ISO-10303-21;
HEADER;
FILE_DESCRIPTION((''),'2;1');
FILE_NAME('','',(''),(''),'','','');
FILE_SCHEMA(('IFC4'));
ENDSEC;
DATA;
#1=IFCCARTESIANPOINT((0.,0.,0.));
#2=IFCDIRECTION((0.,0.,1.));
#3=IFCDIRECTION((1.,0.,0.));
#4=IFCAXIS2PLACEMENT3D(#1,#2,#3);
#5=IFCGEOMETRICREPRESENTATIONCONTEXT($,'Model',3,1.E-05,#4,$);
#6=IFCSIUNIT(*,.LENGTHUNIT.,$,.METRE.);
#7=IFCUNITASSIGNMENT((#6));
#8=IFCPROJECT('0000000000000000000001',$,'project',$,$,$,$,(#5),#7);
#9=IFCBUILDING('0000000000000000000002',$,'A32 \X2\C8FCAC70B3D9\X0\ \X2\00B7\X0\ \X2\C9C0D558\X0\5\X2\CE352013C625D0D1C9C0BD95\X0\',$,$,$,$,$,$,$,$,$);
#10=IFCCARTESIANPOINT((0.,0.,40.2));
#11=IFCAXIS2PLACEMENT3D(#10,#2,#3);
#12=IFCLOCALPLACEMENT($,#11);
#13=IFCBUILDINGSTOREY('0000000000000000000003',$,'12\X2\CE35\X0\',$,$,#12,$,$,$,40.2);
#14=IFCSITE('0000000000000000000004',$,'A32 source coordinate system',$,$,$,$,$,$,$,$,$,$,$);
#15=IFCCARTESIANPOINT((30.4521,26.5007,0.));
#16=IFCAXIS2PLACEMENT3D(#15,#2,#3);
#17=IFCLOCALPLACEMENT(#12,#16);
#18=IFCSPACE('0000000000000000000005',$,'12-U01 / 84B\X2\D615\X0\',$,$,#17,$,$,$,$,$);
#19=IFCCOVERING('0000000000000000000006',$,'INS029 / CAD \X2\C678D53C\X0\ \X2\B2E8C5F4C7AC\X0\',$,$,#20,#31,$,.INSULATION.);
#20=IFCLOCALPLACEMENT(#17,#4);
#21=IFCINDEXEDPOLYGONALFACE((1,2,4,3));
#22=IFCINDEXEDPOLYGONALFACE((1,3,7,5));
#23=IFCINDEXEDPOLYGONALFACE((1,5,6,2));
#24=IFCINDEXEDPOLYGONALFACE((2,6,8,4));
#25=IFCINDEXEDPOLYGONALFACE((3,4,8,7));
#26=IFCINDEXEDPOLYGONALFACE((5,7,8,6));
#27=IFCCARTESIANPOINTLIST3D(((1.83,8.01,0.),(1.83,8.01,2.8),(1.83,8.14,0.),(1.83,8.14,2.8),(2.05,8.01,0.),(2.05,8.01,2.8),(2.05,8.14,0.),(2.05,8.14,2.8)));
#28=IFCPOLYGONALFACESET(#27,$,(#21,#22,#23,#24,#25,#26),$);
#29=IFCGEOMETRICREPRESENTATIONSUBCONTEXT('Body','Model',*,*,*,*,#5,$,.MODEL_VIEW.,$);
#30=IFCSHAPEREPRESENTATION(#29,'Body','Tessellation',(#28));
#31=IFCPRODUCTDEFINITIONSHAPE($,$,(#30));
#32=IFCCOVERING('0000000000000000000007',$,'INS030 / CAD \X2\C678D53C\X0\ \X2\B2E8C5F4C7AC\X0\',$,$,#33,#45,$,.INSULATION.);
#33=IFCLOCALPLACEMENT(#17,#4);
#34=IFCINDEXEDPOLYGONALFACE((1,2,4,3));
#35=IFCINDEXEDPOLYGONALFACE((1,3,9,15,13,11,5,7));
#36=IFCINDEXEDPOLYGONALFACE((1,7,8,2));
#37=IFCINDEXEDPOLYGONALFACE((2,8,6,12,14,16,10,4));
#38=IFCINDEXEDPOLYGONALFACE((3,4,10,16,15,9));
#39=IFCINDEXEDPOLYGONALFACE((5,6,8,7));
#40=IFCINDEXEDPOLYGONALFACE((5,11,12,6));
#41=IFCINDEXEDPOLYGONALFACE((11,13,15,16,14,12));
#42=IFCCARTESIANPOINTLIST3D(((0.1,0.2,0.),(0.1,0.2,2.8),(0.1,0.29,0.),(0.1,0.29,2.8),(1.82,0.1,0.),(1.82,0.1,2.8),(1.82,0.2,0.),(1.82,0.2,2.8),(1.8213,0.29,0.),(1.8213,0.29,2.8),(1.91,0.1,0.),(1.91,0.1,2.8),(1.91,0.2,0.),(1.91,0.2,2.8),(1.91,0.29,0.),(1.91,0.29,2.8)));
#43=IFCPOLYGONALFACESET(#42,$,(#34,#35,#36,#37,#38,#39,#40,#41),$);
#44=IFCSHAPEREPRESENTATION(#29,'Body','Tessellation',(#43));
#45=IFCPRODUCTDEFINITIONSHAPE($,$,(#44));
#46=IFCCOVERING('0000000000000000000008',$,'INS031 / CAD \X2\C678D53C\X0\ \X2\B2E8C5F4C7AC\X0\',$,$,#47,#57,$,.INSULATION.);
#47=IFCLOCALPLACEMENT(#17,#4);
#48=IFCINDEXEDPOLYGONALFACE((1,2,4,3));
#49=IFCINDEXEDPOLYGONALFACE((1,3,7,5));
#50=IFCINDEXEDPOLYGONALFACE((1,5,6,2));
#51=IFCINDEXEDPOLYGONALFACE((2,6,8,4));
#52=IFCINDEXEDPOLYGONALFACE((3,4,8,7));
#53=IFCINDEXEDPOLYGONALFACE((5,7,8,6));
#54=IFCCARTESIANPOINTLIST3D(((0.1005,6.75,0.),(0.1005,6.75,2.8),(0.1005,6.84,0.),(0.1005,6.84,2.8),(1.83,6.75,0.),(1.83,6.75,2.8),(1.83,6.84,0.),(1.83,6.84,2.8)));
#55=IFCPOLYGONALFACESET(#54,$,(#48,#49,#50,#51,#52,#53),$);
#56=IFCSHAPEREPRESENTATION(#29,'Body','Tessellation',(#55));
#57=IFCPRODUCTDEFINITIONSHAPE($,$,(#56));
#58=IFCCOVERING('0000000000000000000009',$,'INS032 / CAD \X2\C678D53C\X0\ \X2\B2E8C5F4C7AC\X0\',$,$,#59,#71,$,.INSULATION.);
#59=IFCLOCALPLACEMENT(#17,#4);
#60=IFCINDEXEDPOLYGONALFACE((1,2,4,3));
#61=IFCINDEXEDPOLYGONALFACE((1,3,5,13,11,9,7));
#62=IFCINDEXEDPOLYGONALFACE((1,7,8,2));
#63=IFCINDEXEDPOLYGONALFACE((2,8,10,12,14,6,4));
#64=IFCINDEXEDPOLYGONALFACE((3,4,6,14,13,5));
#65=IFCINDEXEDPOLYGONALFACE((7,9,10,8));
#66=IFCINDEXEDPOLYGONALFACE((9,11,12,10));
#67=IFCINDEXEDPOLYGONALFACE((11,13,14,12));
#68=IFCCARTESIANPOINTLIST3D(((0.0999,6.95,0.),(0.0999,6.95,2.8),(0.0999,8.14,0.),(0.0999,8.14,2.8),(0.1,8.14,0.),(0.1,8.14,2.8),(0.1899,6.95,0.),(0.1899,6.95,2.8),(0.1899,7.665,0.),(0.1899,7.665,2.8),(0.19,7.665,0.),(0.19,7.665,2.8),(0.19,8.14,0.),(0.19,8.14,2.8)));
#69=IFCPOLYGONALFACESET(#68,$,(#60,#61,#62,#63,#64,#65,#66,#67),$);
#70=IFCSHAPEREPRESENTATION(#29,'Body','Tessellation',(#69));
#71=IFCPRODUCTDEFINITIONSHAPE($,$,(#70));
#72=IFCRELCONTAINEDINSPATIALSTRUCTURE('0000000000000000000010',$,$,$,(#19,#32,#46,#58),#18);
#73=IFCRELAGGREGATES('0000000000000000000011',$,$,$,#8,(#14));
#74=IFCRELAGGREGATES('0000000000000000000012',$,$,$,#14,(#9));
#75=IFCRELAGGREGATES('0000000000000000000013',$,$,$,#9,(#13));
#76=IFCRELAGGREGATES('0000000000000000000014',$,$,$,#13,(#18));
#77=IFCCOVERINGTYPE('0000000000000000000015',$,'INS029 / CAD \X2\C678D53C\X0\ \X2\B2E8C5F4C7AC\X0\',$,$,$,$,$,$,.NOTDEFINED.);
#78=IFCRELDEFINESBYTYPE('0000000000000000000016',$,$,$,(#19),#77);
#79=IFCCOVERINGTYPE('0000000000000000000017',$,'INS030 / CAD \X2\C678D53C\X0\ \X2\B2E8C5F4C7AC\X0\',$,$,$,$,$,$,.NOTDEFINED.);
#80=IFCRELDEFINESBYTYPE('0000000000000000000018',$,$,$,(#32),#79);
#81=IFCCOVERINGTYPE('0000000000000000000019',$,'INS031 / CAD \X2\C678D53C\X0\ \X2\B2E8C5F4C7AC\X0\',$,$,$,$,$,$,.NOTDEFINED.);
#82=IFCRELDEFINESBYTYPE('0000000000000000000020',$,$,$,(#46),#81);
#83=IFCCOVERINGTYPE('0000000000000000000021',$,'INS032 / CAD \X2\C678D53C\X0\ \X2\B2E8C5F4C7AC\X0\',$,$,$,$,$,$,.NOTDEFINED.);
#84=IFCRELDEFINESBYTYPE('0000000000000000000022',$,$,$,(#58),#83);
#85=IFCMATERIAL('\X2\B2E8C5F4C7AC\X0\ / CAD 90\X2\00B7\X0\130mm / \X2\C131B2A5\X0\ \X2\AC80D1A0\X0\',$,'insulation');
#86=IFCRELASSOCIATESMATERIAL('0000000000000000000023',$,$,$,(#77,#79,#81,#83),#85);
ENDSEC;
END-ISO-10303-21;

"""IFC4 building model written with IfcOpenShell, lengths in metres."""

from ifc_helpers import new_model, si_unit, frame, origin, origin_with_axes, place, context, subcontext, project, spatial, polyline, outline, extrude, source, transform, mapped, material, type_object, type_shapes, element, save


model = new_model("IFC4")

# Units and contexts
model_context = context("Model", 3, precision=1e-05, world=origin_with_axes())
body_context = subcontext(model_context, "Body", "Model", "MODEL_VIEW")
ifc_project = project(units=[si_unit("LENGTHUNIT", "METRE")], contexts=[model_context])

# Site, building, storey, space
storey_placement = place(None, frame((0.0, 0.0, 40.2), z_axis=(0.0, 0.0, 1.0), x_axis=(1.0, 0.0, 0.0)))
space_placement = place(storey_placement, frame((30.4521, 26.5007, 0.0), z_axis=(0.0, 0.0, 1.0), x_axis=(1.0, 0.0, 0.0)))
site = spatial("IfcSite", under=ifc_project, Name="A32 source coordinate system")
building = spatial("IfcBuilding", under=site, Name="A32 주거동 · 지하5층–옥탑지붕")
storey = spatial("IfcBuildingStorey", under=building, at=storey_placement, Name="12층", Elevation=40.2)
space = spatial("IfcSpace", under=storey, at=space_placement, Name="12-U01 / 84B형")

# Coverings
ifc_material = material(Name="단열재 / CAD 90·130mm / 성능 검토", Category="insulation")
covering_type_1 = type_object("IfcCoveringType", Name="INS029 / CAD 외피 단열재", PredefinedType="NOTDEFINED", material=ifc_material)
shared_shape_1 = source(origin(), body_context, "Body", "SweptSolid", [
    extrude(outline(polyline([(1.83, 8.01), (1.83, 8.14), (2.05, 8.14), (2.05, 8.01), (1.83, 8.01)])), origin(), (0.0, 0.0, 1.0), 2.8),
])
type_shapes(covering_type_1, [shared_shape_1])
covering_1_placement = place(space_placement, origin_with_axes())
element("IfcCovering", 1, at=covering_1_placement, inside=space, type_object=covering_type_1, Name="INS029 / CAD 외피 단열재", PredefinedType="INSULATION", context=body_context, shape_type="MappedRepresentation", body=[
    mapped(shared_shape_1, transform((0.0, 0.0, 0.0), scale=1.0)),
])
covering_type_2 = type_object("IfcCoveringType", Name="INS030 / CAD 외피 단열재", PredefinedType="NOTDEFINED", material=ifc_material)
shared_shape_2 = source(origin(), body_context, "Body", "SweptSolid", [
    extrude(outline(polyline([(1.91, 0.2), (1.91, 0.1), (1.82, 0.1), (1.82, 0.2), (0.1, 0.2), (0.1, 0.29), (1.8213, 0.29), (1.91, 0.29), (1.91, 0.2)])), origin(), (0.0, 0.0, 1.0), 2.8),
])
type_shapes(covering_type_2, [shared_shape_2])
covering_2_placement = place(space_placement, origin_with_axes())
element("IfcCovering", 2, at=covering_2_placement, inside=space, type_object=covering_type_2, Name="INS030 / CAD 외피 단열재", PredefinedType="INSULATION", context=body_context, shape_type="MappedRepresentation", body=[
    mapped(shared_shape_2, transform((0.0, 0.0, 0.0), scale=1.0)),
])
covering_type_3 = type_object("IfcCoveringType", Name="INS031 / CAD 외피 단열재", PredefinedType="NOTDEFINED", material=ifc_material)
shared_shape_3 = source(origin(), body_context, "Body", "SweptSolid", [
    extrude(outline(polyline([(1.83, 6.75), (0.1005, 6.75), (0.1005, 6.84), (1.83, 6.84), (1.83, 6.75)])), origin(), (0.0, 0.0, 1.0), 2.8),
])
type_shapes(covering_type_3, [shared_shape_3])
covering_3_placement = place(space_placement, origin_with_axes())
element("IfcCovering", 3, at=covering_3_placement, inside=space, type_object=covering_type_3, Name="INS031 / CAD 외피 단열재", PredefinedType="INSULATION", context=body_context, shape_type="MappedRepresentation", body=[
    mapped(shared_shape_3, transform((0.0, 0.0, 0.0), scale=1.0)),
])
covering_type_4 = type_object("IfcCoveringType", Name="INS032 / CAD 외피 단열재", PredefinedType="NOTDEFINED", material=ifc_material)
shared_shape_4 = source(origin(), body_context, "Body", "SweptSolid", [
    extrude(outline(polyline([(0.1899, 6.95), (0.0999, 6.95), (0.0999, 8.14), (0.1, 8.14), (0.19, 8.14), (0.19, 7.665), (0.1899, 7.665), (0.1899, 6.95)])), origin(), (0.0, 0.0, 1.0), 2.8),
])
type_shapes(covering_type_4, [shared_shape_4])
covering_4_placement = place(space_placement, origin_with_axes())
element("IfcCovering", 4, at=covering_4_placement, inside=space, type_object=covering_type_4, Name="INS032 / CAD 외피 단열재", PredefinedType="INSULATION", context=body_context, shape_type="MappedRepresentation", body=[
    mapped(shared_shape_4, transform((0.0, 0.0, 0.0), scale=1.0)),
])

save(model, "model.ifc")
